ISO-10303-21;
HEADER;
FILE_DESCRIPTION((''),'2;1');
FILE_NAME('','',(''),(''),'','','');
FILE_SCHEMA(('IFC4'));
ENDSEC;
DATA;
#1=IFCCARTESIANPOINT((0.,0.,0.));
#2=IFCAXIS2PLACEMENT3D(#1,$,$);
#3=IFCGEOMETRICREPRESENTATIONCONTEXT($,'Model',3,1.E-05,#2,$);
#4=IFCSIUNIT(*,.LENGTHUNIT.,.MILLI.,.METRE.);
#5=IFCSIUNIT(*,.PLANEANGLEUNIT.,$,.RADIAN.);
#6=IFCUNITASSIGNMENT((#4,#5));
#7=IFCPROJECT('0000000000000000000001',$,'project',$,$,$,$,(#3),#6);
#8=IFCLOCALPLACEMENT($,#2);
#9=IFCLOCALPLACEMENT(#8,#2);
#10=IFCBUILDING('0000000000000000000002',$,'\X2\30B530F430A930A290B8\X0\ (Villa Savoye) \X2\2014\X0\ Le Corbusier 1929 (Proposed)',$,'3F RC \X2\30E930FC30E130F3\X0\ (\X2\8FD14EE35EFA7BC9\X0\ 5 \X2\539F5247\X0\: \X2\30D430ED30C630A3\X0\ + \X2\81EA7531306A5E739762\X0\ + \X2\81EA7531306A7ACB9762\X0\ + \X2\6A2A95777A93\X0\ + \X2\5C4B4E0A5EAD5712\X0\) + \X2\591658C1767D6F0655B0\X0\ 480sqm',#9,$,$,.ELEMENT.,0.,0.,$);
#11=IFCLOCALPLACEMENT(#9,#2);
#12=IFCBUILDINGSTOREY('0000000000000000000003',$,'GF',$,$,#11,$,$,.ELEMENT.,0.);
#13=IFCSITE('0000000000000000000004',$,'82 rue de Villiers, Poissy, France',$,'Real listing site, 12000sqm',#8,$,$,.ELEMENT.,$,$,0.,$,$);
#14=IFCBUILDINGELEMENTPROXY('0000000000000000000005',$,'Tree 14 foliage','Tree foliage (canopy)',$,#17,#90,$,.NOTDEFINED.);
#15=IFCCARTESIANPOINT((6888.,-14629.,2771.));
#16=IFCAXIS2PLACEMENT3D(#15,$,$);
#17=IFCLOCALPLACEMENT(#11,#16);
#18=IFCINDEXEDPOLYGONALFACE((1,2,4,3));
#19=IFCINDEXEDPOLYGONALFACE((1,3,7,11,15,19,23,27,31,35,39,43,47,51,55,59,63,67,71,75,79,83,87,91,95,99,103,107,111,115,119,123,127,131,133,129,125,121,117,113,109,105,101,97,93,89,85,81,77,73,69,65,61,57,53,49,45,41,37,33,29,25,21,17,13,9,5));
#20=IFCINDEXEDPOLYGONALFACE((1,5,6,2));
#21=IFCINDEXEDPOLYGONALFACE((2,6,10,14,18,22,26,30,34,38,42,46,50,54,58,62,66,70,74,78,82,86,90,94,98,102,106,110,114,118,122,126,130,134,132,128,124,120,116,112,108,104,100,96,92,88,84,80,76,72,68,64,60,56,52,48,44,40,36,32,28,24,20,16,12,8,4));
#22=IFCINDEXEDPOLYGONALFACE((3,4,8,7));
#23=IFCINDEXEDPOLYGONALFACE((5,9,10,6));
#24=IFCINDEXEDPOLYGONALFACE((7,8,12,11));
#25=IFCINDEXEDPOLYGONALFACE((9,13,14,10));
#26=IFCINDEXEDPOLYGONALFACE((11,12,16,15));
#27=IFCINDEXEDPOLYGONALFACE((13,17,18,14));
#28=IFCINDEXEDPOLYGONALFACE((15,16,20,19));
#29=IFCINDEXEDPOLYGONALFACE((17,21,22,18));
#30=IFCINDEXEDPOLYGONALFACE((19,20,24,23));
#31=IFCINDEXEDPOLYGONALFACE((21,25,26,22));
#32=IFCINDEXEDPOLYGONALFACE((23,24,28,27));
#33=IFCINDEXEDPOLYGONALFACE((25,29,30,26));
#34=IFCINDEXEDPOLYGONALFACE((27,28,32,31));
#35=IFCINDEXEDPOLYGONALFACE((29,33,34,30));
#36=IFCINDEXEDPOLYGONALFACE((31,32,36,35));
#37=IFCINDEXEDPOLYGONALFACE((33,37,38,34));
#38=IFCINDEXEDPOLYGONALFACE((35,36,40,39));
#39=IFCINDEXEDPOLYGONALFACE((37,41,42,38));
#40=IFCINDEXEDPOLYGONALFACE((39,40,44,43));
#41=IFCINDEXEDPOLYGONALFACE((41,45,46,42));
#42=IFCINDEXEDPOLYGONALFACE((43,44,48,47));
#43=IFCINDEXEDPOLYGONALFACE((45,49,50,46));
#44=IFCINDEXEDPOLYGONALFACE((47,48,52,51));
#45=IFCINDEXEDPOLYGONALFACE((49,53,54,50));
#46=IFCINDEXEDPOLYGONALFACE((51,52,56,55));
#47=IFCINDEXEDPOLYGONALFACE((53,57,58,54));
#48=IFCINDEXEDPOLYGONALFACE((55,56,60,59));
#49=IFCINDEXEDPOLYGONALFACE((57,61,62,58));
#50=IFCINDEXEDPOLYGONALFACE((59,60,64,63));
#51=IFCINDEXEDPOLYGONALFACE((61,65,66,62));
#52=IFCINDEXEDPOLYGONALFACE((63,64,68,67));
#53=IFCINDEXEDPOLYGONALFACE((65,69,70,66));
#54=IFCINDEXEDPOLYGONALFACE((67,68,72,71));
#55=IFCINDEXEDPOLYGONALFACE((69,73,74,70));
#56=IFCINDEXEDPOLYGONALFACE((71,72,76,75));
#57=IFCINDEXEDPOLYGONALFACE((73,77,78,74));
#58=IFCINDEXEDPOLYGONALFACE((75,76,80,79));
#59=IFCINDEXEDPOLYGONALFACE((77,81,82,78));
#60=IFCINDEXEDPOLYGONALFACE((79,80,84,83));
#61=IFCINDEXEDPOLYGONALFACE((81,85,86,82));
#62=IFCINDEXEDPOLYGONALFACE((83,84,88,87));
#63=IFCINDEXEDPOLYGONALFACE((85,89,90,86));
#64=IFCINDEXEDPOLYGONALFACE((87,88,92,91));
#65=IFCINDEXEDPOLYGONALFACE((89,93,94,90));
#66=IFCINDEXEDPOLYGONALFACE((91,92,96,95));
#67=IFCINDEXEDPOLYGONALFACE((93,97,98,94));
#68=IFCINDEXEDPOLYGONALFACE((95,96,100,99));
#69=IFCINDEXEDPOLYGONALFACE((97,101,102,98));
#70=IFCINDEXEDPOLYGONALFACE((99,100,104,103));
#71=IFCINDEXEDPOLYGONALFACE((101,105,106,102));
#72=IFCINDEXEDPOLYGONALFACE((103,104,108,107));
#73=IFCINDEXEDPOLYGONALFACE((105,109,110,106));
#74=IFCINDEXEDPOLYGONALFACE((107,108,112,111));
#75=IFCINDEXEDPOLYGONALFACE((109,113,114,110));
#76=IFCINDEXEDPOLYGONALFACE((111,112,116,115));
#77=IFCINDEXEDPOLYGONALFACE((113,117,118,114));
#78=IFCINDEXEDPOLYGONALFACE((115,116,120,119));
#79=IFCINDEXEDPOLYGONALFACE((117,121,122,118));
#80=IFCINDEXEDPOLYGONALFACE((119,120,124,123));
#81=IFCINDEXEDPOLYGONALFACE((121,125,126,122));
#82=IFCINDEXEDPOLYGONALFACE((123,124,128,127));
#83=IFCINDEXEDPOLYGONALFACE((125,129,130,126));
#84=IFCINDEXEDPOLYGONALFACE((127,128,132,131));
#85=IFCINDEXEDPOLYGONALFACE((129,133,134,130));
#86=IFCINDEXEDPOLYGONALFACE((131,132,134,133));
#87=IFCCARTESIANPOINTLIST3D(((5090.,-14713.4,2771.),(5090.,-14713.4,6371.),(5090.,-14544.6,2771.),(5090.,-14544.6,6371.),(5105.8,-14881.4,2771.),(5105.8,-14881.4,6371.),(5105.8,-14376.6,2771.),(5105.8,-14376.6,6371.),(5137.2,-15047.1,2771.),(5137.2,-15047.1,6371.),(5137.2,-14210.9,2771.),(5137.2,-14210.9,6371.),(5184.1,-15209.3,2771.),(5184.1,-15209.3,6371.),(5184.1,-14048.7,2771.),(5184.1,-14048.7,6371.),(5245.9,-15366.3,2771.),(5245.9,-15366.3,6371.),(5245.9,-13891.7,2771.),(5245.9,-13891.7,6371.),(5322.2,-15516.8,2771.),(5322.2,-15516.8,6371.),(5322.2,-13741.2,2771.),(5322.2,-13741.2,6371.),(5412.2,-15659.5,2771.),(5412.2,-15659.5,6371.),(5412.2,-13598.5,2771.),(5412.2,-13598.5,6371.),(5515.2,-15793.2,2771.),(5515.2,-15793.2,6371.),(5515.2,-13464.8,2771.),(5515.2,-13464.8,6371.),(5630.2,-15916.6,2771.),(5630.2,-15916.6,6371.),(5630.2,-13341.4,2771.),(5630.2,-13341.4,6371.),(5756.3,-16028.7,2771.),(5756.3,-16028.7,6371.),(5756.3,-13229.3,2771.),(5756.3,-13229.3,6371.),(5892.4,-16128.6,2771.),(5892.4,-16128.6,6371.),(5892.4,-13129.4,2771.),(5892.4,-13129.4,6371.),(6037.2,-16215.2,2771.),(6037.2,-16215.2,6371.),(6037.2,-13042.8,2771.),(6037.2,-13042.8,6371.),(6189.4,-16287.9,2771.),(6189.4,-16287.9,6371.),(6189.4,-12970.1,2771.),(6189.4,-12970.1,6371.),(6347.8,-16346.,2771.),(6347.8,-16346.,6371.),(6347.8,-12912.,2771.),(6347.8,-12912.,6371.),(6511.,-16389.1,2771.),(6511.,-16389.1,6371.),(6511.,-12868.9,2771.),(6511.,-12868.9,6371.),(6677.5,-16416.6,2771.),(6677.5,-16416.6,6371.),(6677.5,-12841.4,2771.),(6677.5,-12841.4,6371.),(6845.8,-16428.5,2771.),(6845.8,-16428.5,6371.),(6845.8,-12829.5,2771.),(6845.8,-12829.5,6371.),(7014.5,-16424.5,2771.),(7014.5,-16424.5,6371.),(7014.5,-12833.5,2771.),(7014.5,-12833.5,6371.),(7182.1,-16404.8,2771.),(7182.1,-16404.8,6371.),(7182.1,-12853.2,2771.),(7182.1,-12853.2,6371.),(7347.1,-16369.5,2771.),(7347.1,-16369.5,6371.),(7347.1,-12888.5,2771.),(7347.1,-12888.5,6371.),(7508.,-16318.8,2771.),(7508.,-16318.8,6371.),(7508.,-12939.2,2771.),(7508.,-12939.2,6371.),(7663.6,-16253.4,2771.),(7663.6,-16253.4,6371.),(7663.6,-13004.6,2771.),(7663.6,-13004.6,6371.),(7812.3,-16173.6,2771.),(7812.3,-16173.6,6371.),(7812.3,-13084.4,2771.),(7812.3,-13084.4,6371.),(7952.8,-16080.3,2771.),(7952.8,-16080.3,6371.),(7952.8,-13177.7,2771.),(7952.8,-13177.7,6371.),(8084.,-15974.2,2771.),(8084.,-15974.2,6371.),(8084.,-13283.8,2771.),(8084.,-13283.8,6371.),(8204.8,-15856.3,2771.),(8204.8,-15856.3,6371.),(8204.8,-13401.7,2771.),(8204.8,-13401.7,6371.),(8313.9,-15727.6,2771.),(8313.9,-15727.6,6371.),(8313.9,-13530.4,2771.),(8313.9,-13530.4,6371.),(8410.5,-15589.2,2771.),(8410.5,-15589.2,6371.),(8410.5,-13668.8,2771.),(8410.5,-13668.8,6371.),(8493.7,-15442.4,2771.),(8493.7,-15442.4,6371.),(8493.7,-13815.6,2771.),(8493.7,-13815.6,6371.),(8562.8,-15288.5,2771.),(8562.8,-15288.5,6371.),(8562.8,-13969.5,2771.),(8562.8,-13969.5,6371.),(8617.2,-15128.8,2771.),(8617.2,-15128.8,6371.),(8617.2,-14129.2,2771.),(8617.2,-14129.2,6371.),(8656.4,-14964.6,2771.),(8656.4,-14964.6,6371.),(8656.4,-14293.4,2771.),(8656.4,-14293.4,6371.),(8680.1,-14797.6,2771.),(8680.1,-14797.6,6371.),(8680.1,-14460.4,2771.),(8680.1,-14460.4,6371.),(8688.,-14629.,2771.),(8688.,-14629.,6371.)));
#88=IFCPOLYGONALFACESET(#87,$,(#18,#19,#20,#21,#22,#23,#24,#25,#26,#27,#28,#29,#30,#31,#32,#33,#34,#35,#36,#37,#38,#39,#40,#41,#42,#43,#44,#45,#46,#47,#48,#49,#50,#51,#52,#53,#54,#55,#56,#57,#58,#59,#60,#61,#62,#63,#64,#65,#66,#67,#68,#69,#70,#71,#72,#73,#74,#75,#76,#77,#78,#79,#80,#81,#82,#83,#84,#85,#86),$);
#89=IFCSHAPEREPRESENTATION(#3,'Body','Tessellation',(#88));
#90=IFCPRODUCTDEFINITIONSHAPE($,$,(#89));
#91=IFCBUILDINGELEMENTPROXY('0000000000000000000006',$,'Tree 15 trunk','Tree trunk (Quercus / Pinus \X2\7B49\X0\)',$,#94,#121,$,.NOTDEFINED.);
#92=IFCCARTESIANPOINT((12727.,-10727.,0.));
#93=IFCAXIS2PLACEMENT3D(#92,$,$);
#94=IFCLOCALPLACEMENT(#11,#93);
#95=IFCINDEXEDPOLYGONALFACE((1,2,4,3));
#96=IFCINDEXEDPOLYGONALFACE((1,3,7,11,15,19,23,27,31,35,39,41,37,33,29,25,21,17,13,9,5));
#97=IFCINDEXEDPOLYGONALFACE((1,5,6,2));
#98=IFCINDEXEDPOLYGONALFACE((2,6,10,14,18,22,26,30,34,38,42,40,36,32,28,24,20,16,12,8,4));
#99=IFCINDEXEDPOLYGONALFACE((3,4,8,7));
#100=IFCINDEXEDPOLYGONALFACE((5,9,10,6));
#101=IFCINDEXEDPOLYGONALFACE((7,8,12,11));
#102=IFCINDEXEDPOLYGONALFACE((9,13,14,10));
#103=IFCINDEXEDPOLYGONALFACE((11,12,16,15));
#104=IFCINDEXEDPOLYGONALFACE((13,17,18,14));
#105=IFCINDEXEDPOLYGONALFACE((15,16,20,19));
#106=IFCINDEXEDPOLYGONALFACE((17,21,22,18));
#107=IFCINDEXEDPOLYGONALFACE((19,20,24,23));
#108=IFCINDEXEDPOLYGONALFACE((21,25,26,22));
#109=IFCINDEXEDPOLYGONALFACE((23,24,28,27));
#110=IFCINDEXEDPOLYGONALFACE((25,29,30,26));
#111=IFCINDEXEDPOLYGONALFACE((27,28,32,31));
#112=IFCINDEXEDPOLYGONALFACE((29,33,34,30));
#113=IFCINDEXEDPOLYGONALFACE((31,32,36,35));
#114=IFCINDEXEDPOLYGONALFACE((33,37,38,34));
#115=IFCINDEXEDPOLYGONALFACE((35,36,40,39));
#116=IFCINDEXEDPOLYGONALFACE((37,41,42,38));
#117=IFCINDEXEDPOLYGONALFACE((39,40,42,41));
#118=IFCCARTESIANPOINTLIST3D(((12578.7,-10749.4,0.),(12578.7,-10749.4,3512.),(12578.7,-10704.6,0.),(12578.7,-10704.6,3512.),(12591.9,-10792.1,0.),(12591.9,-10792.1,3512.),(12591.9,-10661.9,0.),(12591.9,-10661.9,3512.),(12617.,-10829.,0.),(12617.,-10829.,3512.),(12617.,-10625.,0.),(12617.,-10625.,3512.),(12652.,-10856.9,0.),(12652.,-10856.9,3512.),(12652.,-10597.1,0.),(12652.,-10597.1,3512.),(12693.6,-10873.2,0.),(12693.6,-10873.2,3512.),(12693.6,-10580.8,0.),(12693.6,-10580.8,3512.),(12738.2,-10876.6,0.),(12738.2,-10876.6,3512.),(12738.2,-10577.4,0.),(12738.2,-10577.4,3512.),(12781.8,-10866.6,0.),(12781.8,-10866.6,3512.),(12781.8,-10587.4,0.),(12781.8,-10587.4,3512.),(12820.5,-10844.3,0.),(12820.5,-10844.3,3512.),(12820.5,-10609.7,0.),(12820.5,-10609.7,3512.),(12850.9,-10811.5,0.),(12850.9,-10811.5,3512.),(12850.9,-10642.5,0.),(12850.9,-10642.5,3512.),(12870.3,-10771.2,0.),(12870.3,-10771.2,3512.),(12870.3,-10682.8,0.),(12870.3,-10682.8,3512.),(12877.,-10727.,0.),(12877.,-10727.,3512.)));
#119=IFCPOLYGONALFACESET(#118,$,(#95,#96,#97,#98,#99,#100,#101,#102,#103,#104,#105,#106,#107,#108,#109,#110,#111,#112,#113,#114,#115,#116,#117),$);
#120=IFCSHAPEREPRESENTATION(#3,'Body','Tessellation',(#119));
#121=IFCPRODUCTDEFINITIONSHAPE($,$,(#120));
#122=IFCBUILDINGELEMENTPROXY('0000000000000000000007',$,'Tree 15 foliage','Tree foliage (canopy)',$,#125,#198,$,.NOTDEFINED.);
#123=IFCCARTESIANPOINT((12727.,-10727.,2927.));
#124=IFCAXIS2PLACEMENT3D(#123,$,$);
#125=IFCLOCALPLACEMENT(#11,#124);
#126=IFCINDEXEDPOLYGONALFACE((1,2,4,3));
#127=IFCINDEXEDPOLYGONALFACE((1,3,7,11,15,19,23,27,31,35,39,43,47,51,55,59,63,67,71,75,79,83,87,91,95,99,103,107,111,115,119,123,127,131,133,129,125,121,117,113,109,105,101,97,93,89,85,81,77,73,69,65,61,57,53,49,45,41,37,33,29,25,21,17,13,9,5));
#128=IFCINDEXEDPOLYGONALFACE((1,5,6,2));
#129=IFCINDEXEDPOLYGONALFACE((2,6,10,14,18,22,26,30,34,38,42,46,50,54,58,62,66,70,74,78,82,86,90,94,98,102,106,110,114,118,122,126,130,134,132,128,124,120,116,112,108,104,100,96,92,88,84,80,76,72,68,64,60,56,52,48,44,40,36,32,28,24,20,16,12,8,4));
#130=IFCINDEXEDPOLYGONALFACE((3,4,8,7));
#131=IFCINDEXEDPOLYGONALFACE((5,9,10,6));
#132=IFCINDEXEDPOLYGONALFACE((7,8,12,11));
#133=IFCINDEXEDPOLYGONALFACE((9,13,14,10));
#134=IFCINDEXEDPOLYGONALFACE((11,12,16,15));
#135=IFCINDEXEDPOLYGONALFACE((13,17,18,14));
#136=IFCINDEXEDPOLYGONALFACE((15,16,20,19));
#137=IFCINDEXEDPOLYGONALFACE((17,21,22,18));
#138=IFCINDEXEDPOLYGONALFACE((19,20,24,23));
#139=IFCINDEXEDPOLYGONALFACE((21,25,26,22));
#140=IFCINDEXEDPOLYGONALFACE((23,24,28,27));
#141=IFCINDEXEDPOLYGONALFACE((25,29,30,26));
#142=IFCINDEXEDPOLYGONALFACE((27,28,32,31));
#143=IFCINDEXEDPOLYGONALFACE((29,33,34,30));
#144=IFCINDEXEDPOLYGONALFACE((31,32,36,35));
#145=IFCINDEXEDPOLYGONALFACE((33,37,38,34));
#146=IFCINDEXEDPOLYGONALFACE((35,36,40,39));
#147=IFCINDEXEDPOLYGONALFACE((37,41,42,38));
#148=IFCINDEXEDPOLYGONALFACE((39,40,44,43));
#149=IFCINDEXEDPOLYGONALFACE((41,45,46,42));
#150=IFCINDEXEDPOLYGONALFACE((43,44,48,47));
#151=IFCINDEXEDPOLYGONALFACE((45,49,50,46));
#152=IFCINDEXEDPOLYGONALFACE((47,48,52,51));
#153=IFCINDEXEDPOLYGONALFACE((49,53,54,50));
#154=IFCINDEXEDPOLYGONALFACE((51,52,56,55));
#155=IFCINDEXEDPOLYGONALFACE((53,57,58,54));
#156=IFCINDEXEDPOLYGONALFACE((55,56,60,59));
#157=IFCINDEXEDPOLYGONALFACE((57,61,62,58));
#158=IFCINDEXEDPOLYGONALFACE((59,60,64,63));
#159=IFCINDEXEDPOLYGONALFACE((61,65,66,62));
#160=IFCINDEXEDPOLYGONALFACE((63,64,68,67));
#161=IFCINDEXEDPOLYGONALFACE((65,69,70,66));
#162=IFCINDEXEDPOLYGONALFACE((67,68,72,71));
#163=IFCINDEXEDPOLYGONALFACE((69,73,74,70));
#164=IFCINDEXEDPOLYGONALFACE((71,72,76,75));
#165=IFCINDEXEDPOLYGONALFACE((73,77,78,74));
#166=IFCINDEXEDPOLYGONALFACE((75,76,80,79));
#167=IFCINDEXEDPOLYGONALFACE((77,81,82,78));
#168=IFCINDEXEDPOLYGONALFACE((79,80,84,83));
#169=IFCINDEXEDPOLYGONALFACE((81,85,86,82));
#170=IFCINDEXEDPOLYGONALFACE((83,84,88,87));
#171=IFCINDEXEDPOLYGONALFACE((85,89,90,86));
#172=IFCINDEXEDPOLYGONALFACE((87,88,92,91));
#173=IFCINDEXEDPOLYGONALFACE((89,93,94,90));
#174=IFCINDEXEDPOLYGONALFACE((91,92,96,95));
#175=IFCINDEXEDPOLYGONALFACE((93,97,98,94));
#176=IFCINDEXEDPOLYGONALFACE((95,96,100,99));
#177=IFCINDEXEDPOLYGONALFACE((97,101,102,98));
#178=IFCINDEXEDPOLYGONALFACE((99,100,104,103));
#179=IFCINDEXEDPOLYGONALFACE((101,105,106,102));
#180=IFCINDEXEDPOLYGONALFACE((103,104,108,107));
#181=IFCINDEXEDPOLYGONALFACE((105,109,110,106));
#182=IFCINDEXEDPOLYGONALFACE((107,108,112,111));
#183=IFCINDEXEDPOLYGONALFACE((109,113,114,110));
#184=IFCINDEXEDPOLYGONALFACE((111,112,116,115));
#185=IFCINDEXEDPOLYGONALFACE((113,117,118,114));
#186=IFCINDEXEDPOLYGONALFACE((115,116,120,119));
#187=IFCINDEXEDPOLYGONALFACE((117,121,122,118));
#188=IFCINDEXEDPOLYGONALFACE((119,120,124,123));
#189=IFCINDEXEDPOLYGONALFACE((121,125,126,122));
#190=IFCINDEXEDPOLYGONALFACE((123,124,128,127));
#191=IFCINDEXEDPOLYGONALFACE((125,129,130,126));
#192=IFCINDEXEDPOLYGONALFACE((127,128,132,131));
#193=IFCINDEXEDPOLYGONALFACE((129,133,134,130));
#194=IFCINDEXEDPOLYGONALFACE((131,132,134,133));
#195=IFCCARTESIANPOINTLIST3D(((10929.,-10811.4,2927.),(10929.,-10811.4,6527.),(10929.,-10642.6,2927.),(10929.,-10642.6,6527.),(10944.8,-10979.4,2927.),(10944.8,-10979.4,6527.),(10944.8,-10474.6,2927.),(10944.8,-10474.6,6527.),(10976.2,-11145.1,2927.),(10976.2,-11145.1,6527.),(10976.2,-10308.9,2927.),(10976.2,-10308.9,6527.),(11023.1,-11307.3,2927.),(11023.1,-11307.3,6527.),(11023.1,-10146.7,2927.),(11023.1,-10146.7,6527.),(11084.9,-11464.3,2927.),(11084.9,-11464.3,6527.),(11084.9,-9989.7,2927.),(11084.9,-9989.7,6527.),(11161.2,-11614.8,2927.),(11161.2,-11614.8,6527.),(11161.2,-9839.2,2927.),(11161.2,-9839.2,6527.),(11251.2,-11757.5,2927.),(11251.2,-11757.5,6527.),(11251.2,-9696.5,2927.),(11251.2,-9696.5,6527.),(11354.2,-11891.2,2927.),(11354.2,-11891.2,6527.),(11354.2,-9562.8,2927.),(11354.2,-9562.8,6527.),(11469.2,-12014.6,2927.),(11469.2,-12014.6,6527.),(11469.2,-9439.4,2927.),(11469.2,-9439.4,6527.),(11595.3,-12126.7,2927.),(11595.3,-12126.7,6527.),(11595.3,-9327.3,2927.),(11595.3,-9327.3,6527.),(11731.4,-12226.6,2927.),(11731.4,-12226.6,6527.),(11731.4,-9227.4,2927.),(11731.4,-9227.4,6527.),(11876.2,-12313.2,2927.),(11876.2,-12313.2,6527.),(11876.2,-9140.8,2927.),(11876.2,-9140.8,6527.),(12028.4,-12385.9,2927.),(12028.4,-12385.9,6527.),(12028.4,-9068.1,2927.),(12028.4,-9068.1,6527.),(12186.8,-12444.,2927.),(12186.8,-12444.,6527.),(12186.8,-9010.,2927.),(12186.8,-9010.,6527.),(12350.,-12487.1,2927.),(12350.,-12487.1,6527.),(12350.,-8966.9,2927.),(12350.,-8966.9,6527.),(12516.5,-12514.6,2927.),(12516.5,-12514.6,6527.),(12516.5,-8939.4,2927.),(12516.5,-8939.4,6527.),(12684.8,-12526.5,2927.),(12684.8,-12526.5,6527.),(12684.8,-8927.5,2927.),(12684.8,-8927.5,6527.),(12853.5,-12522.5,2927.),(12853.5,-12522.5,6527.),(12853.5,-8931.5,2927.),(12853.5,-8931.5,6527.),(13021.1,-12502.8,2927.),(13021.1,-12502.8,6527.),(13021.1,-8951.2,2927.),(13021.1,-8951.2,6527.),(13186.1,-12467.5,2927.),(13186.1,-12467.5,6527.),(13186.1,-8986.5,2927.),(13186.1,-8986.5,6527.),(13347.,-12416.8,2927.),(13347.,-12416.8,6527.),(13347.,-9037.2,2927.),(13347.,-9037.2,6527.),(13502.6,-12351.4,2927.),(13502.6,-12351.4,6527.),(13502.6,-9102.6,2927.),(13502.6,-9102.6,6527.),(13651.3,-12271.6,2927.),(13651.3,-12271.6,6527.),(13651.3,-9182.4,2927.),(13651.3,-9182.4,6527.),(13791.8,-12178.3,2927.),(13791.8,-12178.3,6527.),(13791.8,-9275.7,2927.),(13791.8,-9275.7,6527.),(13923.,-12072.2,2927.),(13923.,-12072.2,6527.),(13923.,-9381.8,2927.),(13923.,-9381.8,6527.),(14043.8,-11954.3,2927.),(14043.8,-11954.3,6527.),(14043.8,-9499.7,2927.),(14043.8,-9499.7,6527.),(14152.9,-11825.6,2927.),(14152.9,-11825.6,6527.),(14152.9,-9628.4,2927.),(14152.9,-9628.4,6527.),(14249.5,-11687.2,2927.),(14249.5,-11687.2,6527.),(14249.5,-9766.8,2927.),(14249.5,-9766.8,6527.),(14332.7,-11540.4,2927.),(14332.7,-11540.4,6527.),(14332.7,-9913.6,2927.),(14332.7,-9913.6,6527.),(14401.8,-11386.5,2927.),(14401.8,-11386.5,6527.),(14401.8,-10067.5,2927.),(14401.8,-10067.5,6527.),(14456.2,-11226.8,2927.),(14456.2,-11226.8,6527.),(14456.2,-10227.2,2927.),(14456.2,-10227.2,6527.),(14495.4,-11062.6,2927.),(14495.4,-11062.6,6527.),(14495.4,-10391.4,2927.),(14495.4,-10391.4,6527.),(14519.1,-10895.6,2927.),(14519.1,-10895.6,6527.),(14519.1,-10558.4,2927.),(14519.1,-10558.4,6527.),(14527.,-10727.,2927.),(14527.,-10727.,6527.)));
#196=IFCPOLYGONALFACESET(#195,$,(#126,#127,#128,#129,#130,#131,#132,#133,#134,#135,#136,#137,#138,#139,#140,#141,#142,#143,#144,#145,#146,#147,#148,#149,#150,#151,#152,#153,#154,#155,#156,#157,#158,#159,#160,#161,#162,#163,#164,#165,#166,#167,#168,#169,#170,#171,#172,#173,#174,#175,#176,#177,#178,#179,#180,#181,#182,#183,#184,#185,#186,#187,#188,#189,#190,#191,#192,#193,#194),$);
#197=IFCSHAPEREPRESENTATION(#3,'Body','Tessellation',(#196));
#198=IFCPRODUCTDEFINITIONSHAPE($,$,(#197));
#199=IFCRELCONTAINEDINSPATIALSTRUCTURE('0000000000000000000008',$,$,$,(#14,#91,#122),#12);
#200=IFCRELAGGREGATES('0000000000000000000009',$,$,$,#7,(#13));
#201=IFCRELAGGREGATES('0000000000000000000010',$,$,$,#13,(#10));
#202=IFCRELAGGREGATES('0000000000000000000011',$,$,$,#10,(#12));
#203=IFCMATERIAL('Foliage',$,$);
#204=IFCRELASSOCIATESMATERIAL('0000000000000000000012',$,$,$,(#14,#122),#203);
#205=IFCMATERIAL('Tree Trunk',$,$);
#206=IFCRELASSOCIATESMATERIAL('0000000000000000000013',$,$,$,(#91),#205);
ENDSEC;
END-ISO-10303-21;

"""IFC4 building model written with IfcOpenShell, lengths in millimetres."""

from ifc_helpers import new_model, si_unit, frame, origin, origin_2d, place, context, project, spatial, circle, extrude, material, element, save


model = new_model("IFC4")

# Units and contexts
model_context = context("Model", 3, precision=1e-05, world=origin())
ifc_project = project(units=[si_unit("LENGTHUNIT", "METRE", prefix="MILLI"), si_unit("PLANEANGLEUNIT", "RADIAN")], contexts=[model_context])

# Site, building, storey
site_placement = place(None, origin())
site = spatial("IfcSite", under=ifc_project, at=site_placement, Name="82 rue de Villiers, Poissy, France", ObjectType="Real listing site, 12000sqm", CompositionType="ELEMENT", RefElevation=0.0)
building_placement = place(site_placement, origin())
building = spatial("IfcBuilding", under=site, at=building_placement, Name="サヴォア邸 (Villa Savoye) — Le Corbusier 1929 (Proposed)", ObjectType="3F RC ラーメン (近代建築 5 原則: ピロティ + 自由な平面 + 自由な立面 + 横長窓 + 屋上庭園) + 外壁白漆喰 480sqm", CompositionType="ELEMENT", ElevationOfRefHeight=0.0, ElevationOfTerrain=0.0)
storey_placement = place(building_placement, origin())
storey = spatial("IfcBuildingStorey", under=building, at=storey_placement, Name="GF", CompositionType="ELEMENT", Elevation=0.0)

# Building element proxies
ifc_material_1 = material(Name="Tree Trunk")
ifc_material_2 = material(Name="Foliage")
proxy_1_placement = place(storey_placement, frame((6888.0, -14629.0, 2771.0)))
element("IfcBuildingElementProxy", 1, at=proxy_1_placement, inside=storey, material=ifc_material_2, Name="Tree 14 foliage", Description="Tree foliage (canopy)", PredefinedType="NOTDEFINED", context=model_context, shape_type="SweptSolid", body=[
    extrude(circle(Radius=1800.0, at=origin_2d()), frame((6888.0, -14629.0, 2771.0)), (0.0, 0.0, 1.0), 3600.0),
])
proxy_2_placement = place(storey_placement, frame((12727.0, -10727.0, 0.0)))
element("IfcBuildingElementProxy", 2, at=proxy_2_placement, inside=storey, material=ifc_material_1, Name="Tree 15 trunk", Description="Tree trunk (Quercus / Pinus 等)", PredefinedType="NOTDEFINED", context=model_context, shape_type="SweptSolid", body=[
    extrude(circle(Radius=150.0, at=origin_2d()), frame((12727.0, -10727.0, 0.0)), (0.0, 0.0, 1.0), 3512.0),
])
proxy_3_placement = place(storey_placement, frame((12727.0, -10727.0, 2927.0)))
element("IfcBuildingElementProxy", 3, at=proxy_3_placement, inside=storey, material=ifc_material_2, Name="Tree 15 foliage", Description="Tree foliage (canopy)", PredefinedType="NOTDEFINED", context=model_context, shape_type="SweptSolid", body=[
    extrude(circle(Radius=1800.0, at=origin_2d()), frame((12727.0, -10727.0, 2927.0)), (0.0, 0.0, 1.0), 3600.0),
])

save(model, "model.ifc")
